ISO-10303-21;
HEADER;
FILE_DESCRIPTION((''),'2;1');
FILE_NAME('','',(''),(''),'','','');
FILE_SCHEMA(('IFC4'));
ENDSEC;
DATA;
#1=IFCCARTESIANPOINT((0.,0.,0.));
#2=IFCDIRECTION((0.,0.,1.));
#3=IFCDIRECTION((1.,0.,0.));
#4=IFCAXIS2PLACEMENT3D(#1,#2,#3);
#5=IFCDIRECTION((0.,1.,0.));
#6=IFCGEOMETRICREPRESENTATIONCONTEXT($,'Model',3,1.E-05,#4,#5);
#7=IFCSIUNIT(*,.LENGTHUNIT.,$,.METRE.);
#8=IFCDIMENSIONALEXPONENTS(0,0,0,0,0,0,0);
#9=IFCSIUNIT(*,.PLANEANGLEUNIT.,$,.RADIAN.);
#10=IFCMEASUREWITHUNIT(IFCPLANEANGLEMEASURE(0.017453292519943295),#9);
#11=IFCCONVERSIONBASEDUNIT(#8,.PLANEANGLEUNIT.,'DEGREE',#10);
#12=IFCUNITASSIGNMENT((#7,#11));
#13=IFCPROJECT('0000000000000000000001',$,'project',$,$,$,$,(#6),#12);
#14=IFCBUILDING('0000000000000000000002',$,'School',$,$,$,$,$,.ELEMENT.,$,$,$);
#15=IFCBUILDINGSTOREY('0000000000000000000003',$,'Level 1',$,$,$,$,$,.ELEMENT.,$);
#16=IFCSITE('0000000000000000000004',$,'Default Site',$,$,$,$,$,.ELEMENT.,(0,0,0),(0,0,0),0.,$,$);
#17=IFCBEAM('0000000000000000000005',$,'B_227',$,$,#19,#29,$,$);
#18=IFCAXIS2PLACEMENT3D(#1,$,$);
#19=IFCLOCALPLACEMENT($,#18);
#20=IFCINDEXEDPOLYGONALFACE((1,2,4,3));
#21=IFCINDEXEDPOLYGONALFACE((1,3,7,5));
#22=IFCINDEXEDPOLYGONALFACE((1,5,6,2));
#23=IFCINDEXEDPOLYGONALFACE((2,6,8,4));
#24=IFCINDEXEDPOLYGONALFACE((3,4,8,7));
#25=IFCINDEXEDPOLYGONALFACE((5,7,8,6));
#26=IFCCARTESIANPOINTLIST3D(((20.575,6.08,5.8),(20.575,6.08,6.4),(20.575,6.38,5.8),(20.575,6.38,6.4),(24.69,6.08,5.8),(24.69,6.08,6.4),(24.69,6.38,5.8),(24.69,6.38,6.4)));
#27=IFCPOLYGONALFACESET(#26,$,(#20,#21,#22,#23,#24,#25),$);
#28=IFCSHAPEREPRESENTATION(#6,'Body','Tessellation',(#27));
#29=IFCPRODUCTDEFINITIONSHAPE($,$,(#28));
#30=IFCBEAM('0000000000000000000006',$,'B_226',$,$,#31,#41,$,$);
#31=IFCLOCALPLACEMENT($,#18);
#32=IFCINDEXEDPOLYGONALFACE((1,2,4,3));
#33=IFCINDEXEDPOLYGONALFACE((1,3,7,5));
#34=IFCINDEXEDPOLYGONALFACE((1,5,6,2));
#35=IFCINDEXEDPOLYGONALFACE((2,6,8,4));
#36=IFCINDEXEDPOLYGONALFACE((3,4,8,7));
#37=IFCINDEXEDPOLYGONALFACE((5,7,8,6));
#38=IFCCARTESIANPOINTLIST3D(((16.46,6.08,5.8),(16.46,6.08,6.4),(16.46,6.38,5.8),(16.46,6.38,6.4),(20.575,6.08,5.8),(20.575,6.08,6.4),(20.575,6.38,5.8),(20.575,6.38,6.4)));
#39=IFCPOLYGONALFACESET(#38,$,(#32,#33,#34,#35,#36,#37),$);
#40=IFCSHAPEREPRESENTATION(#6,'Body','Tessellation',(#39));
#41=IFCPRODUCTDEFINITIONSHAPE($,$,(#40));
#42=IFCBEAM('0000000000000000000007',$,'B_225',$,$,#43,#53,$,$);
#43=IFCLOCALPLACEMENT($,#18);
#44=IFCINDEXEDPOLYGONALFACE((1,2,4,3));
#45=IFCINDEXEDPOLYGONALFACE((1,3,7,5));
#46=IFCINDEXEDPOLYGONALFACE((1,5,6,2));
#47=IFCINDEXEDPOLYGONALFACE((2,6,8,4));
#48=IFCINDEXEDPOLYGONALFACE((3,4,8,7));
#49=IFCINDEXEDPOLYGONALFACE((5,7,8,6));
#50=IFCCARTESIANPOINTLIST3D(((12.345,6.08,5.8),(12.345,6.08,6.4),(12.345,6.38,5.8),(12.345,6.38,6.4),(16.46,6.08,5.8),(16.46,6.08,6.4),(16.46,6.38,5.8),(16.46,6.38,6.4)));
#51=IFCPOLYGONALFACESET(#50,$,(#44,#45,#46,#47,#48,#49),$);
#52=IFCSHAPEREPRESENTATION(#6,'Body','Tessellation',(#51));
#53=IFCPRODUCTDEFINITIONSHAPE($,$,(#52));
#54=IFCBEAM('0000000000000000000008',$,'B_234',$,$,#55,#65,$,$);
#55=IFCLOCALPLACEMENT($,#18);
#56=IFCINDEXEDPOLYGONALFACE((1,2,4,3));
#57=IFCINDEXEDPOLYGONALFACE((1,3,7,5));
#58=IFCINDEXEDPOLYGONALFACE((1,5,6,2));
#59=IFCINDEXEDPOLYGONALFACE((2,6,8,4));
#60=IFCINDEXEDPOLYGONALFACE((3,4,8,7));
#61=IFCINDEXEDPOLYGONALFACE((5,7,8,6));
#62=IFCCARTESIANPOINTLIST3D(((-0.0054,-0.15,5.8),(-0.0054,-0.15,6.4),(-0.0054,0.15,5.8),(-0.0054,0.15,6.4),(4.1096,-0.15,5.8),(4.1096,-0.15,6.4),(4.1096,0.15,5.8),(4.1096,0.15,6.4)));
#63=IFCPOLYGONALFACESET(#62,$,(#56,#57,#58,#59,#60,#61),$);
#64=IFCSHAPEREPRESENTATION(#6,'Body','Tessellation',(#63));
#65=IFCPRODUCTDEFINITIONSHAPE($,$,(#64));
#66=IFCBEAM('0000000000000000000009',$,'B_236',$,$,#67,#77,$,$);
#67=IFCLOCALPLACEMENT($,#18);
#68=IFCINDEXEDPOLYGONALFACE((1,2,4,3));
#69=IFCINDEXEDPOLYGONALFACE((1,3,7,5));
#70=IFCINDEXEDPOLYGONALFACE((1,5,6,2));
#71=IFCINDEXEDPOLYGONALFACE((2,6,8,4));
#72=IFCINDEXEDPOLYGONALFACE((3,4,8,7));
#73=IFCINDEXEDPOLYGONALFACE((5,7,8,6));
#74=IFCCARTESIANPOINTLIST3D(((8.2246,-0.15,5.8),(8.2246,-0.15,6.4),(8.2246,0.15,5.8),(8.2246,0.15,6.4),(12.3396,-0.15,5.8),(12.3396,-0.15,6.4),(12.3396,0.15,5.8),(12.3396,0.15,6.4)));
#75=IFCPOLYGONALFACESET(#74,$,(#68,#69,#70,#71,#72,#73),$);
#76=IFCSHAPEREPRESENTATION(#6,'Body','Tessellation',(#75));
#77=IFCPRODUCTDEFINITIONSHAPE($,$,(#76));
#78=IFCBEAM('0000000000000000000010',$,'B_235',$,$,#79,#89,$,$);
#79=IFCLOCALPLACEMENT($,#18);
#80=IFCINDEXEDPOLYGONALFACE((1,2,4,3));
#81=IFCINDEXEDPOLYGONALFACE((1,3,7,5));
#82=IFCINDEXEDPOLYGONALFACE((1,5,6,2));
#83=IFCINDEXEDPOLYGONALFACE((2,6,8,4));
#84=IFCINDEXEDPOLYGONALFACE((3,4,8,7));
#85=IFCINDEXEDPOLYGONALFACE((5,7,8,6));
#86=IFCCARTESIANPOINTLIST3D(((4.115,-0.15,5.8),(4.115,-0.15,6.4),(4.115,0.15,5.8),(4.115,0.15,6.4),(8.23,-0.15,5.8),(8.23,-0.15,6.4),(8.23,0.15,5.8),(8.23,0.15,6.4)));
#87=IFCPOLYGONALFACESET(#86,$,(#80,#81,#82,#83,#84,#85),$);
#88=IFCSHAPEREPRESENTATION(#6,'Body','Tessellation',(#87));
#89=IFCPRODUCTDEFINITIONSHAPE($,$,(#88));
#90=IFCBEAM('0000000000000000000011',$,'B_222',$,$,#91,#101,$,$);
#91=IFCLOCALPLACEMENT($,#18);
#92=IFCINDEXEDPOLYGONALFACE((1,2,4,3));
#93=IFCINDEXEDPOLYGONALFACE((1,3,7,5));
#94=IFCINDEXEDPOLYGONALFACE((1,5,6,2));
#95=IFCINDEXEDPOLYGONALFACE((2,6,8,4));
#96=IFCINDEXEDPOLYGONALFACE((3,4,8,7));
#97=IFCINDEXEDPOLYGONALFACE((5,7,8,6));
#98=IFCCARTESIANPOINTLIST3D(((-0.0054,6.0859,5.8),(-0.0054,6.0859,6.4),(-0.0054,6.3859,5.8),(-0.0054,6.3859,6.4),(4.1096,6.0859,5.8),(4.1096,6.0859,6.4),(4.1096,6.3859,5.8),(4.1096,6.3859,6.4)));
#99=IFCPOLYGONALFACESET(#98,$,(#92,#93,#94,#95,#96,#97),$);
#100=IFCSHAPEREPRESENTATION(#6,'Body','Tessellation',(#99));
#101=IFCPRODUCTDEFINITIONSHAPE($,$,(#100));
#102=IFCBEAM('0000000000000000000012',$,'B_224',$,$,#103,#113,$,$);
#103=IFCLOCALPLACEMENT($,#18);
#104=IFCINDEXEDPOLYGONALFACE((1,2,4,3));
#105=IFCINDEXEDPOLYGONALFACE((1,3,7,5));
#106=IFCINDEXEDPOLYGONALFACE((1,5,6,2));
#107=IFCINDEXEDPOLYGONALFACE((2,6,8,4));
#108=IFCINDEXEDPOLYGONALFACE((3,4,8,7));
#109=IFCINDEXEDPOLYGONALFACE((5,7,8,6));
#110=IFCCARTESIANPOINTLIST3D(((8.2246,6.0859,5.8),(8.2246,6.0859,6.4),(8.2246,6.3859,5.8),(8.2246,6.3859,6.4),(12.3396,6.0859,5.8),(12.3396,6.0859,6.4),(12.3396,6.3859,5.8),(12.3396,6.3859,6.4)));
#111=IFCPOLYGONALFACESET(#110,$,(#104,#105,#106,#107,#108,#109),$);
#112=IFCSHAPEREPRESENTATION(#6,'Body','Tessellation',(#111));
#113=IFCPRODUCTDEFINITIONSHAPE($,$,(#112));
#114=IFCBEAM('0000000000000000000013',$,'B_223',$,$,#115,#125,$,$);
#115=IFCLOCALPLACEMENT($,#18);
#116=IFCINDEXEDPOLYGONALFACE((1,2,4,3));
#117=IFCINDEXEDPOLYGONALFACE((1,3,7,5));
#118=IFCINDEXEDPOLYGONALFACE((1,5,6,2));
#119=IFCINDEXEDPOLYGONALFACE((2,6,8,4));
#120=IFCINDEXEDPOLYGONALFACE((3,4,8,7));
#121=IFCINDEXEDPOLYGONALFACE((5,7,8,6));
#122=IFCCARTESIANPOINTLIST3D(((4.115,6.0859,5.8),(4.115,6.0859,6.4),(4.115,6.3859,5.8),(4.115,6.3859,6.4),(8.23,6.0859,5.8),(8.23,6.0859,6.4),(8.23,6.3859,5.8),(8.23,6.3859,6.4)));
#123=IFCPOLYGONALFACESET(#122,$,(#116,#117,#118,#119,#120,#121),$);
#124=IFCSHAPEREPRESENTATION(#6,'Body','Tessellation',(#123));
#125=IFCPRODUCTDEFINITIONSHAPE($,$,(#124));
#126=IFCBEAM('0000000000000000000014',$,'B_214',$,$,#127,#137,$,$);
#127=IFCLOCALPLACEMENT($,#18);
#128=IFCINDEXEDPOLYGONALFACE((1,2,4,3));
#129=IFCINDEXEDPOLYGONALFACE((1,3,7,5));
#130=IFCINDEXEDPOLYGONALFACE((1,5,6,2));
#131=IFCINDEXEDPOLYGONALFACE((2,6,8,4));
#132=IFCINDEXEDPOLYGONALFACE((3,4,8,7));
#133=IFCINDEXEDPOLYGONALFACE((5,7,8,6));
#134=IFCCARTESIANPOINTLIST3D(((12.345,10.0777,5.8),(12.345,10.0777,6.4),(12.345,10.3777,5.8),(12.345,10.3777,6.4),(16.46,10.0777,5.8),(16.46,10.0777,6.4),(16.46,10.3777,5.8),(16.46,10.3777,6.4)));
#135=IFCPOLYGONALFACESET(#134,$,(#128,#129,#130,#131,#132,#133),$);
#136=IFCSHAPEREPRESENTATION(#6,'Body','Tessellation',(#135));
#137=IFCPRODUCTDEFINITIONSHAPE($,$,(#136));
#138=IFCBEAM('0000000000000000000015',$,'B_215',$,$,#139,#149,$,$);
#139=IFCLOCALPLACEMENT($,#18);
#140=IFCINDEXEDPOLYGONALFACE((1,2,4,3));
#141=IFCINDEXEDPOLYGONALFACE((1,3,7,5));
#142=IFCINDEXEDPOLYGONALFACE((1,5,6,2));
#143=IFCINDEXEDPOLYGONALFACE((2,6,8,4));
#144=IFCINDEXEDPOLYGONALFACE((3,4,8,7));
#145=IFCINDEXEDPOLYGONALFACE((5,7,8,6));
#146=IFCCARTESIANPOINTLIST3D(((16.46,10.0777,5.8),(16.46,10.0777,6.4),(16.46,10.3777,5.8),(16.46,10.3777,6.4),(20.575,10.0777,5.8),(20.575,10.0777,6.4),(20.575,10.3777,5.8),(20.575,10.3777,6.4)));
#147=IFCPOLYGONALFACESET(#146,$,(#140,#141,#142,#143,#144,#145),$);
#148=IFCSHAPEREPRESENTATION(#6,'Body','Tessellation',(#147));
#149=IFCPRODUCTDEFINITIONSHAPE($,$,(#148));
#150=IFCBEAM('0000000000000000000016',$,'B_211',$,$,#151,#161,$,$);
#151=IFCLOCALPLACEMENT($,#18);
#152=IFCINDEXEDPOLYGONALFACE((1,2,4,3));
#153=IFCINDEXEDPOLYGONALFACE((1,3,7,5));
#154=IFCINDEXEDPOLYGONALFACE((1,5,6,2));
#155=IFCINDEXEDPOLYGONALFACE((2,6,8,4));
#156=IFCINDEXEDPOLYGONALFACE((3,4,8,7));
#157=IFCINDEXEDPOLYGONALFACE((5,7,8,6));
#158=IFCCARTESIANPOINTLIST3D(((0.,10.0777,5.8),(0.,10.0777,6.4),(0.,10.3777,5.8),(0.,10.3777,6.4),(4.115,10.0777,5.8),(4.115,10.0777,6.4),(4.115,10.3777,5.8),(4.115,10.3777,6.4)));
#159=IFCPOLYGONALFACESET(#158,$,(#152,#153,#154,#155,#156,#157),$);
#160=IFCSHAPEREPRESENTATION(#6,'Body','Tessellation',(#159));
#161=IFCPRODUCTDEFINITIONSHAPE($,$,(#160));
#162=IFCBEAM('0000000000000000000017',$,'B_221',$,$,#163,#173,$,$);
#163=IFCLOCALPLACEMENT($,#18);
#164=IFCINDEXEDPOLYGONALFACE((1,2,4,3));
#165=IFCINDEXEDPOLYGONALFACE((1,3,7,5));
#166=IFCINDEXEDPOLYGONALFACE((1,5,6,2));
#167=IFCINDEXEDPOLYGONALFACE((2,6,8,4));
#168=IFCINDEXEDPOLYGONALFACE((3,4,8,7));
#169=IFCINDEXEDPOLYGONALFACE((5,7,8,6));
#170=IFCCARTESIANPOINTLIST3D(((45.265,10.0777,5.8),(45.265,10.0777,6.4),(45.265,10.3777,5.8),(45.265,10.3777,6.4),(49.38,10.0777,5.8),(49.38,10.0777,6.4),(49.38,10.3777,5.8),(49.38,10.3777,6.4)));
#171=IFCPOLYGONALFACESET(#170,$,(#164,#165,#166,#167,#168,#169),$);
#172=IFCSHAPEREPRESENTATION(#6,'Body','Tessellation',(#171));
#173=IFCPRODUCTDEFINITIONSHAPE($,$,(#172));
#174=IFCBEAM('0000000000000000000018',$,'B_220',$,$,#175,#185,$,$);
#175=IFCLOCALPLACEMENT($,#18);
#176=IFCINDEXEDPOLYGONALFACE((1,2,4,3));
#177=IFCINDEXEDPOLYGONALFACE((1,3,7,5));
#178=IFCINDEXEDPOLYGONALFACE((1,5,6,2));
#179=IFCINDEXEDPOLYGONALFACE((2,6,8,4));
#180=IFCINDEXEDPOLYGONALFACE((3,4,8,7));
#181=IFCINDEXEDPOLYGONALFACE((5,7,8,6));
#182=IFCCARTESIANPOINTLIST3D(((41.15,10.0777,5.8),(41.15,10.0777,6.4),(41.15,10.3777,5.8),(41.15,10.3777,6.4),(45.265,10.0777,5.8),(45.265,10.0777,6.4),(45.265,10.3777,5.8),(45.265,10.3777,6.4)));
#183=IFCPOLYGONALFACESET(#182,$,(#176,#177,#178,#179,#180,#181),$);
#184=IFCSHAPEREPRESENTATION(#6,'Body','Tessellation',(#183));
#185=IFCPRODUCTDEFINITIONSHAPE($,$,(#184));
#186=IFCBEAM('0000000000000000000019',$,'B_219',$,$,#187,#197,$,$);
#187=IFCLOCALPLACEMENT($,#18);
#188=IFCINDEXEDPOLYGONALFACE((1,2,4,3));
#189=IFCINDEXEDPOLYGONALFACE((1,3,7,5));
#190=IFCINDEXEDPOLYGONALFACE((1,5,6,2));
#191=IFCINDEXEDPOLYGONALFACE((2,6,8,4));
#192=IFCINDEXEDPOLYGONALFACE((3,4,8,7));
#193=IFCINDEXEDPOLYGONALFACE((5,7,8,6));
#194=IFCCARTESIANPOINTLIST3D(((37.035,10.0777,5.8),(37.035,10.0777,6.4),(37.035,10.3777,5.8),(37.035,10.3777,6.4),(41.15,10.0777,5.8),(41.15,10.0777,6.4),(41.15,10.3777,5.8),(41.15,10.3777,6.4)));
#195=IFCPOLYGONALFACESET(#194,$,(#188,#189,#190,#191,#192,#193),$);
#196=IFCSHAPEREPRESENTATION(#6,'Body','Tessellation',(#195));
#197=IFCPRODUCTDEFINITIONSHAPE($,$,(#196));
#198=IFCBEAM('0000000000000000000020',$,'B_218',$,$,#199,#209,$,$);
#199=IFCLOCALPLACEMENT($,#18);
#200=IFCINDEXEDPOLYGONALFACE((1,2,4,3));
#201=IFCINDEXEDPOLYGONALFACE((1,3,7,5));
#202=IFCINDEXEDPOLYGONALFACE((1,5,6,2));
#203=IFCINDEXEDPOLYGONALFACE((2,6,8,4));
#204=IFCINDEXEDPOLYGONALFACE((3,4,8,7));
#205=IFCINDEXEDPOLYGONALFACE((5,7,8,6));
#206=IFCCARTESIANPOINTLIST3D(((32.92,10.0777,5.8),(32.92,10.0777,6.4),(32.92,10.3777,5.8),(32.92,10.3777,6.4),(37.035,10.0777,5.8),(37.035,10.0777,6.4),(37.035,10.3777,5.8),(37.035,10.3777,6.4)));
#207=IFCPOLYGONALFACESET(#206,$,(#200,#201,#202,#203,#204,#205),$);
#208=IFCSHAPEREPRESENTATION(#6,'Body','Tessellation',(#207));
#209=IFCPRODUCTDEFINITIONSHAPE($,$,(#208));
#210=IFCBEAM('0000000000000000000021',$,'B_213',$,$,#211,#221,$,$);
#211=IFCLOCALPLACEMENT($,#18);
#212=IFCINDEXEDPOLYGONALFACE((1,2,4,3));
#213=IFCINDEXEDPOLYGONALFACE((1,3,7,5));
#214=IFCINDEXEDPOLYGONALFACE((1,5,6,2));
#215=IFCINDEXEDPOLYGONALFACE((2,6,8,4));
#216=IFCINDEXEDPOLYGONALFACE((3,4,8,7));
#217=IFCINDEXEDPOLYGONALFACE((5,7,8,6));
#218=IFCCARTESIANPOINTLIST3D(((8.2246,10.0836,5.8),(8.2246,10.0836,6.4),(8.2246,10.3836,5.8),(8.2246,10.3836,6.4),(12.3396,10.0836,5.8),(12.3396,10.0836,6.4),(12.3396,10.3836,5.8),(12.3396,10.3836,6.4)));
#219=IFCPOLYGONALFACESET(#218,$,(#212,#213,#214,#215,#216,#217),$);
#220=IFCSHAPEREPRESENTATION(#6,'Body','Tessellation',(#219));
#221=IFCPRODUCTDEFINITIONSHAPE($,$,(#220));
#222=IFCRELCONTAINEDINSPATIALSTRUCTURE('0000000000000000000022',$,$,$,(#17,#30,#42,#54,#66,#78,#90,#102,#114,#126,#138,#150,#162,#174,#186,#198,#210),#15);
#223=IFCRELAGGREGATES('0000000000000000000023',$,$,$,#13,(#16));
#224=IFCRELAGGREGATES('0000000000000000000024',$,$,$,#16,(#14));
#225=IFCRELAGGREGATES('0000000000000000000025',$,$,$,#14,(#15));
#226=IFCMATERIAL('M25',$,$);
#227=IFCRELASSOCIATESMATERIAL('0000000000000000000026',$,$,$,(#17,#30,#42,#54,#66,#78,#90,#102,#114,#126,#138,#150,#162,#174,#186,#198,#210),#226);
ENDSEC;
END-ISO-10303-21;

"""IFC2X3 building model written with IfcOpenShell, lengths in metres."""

from ifc_helpers import new_model, entity, si_unit, converted_unit, direction, frame, frame_2d, origin_with_axes, place, context, project, spatial, rectangle, extrude, material, element, save


model = new_model("IFC2X3")

# Units and contexts
model_context = context("Model", 3, precision=1e-05, world=origin_with_axes(), true_north=direction((0.0, 1.0, 0.0)))
ifc_project = project(units=[si_unit("LENGTHUNIT", "METRE"), converted_unit("PLANEANGLEUNIT", "DEGREE", entity("IfcPlaneAngleMeasure", 0.017453292519943295), si_unit("PLANEANGLEUNIT", "RADIAN"), dimensions=[0, 0, 0, 0, 0, 0, 0])], contexts=[model_context])

# Site, building, storey
site = spatial("IfcSite", under=ifc_project, Name="Default Site", CompositionType="ELEMENT", RefLatitude=(0, 0, 0), RefLongitude=(0, 0, 0), RefElevation=0.0)
building = spatial("IfcBuilding", under=site, Name="School", CompositionType="ELEMENT")
storey = spatial("IfcBuildingStorey", under=building, Name="Level 1", CompositionType="ELEMENT")

# Beams
ifc_material = material(Name="M25")
placement = place(None, origin_with_axes())
element("IfcBeam", 1, at=placement, inside=storey, material=ifc_material, Name="B_227", context=model_context, shape_type="SweptSolid", body=[
    extrude(rectangle(XDim=0.3, YDim=0.6, at=frame_2d((0.0, 0.0), x_axis=(0.0, 1.0, 0.0))), frame((20.575, 6.23, 6.1), z_axis=(1.0, 0.0, 0.0), x_axis=(0.0, 0.0, -1.0)), (0.0, 0.0, 1.0), 4.115),
])
element("IfcBeam", 2, at=placement, inside=storey, material=ifc_material, Name="B_226", context=model_context, shape_type="SweptSolid", body=[
    extrude(rectangle(XDim=0.3, YDim=0.6, at=frame_2d((0.0, 0.0), x_axis=(0.0, 1.0, 0.0))), frame((16.46, 6.23, 6.1), z_axis=(1.0, 0.0, 0.0), x_axis=(0.0, 0.0, -1.0)), (0.0, 0.0, 1.0), 4.115),
])
element("IfcBeam", 3, at=placement, inside=storey, material=ifc_material, Name="B_225", context=model_context, shape_type="SweptSolid", body=[
    extrude(rectangle(XDim=0.3, YDim=0.6, at=frame_2d((0.0, 0.0), x_axis=(0.0, 1.0, 0.0))), frame((12.345, 6.23, 6.1), z_axis=(1.0, 0.0, 0.0), x_axis=(0.0, 0.0, -1.0)), (0.0, 0.0, 1.0), 4.115),
])
element("IfcBeam", 4, at=placement, inside=storey, material=ifc_material, Name="B_234", context=model_context, shape_type="SweptSolid", body=[
    extrude(rectangle(XDim=0.3, YDim=0.6, at=frame_2d((0.0, 0.0), x_axis=(0.0, 1.0, 0.0))), frame((-0.0054, 0.0, 6.1), z_axis=(1.0, 0.0, 0.0), x_axis=(0.0, 0.0, -1.0)), (0.0, 0.0, 1.0), 4.115),
])
element("IfcBeam", 5, at=placement, inside=storey, material=ifc_material, Name="B_236", context=model_context, shape_type="SweptSolid", body=[
    extrude(rectangle(XDim=0.3, YDim=0.6, at=frame_2d((0.0, 0.0), x_axis=(0.0, 1.0, 0.0))), frame((8.2246, 0.0, 6.1), z_axis=(1.0, 0.0, 0.0), x_axis=(0.0, 0.0, -1.0)), (0.0, 0.0, 1.0), 4.115),
])
element("IfcBeam", 6, at=placement, inside=storey, material=ifc_material, Name="B_235", context=model_context, shape_type="SweptSolid", body=[
    extrude(rectangle(XDim=0.3, YDim=0.6, at=frame_2d((0.0, 0.0), x_axis=(0.0, 1.0, 0.0))), frame((4.115, 0.0, 6.1), z_axis=(1.0, 0.0, 0.0), x_axis=(0.0, 0.0, -1.0)), (0.0, 0.0, 1.0), 4.115),
])
element("IfcBeam", 7, at=placement, inside=storey, material=ifc_material, Name="B_222", context=model_context, shape_type="SweptSolid", body=[
    extrude(rectangle(XDim=0.3, YDim=0.6, at=frame_2d((0.0, 0.0), x_axis=(0.0, 1.0, 0.0))), frame((-0.0054, 6.2359, 6.1), z_axis=(1.0, 0.0, 0.0), x_axis=(0.0, 0.0, -1.0)), (0.0, 0.0, 1.0), 4.115),
])
element("IfcBeam", 8, at=placement, inside=storey, material=ifc_material, Name="B_224", context=model_context, shape_type="SweptSolid", body=[
    extrude(rectangle(XDim=0.3, YDim=0.6, at=frame_2d((0.0, 0.0), x_axis=(0.0, 1.0, 0.0))), frame((8.2246, 6.2359, 6.1), z_axis=(1.0, 0.0, 0.0), x_axis=(0.0, 0.0, -1.0)), (0.0, 0.0, 1.0), 4.115),
])
element("IfcBeam", 9, at=placement, inside=storey, material=ifc_material, Name="B_223", context=model_context, shape_type="SweptSolid", body=[
    extrude(rectangle(XDim=0.3, YDim=0.6, at=frame_2d((0.0, 0.0), x_axis=(0.0, 1.0, 0.0))), frame((4.115, 6.2359, 6.1), z_axis=(1.0, 0.0, 0.0), x_axis=(0.0, 0.0, -1.0)), (0.0, 0.0, 1.0), 4.115),
])
element("IfcBeam", 10, at=placement, inside=storey, material=ifc_material, Name="B_214", context=model_context, shape_type="SweptSolid", body=[
    extrude(rectangle(XDim=0.3, YDim=0.6, at=frame_2d((0.0, 0.0), x_axis=(0.0, 1.0, 0.0))), frame((12.345, 10.2277, 6.1), z_axis=(1.0, 0.0, 0.0), x_axis=(0.0, 0.0, -1.0)), (0.0, 0.0, 1.0), 4.115),
])
element("IfcBeam", 11, at=placement, inside=storey, material=ifc_material, Name="B_215", context=model_context, shape_type="SweptSolid", body=[
    extrude(rectangle(XDim=0.3, YDim=0.6, at=frame_2d((0.0, 0.0), x_axis=(0.0, 1.0, 0.0))), frame((16.46, 10.2277, 6.1), z_axis=(1.0, 0.0, 0.0), x_axis=(0.0, 0.0, -1.0)), (0.0, 0.0, 1.0), 4.115),
])
element("IfcBeam", 12, at=placement, inside=storey, material=ifc_material, Name="B_211", context=model_context, shape_type="SweptSolid", body=[
    extrude(rectangle(XDim=0.3, YDim=0.6, at=frame_2d((0.0, 0.0), x_axis=(0.0, 1.0, 0.0))), frame((0.0, 10.2277, 6.1), z_axis=(1.0, 0.0, 0.0), x_axis=(0.0, 0.0, -1.0)), (0.0, 0.0, 1.0), 4.115),
])
element("IfcBeam", 13, at=placement, inside=storey, material=ifc_material, Name="B_221", context=model_context, shape_type="SweptSolid", body=[
    extrude(rectangle(XDim=0.3, YDim=0.6, at=frame_2d((0.0, 0.0), x_axis=(0.0, 1.0, 0.0))), frame((45.265, 10.2277, 6.1), z_axis=(1.0, 0.0, 0.0), x_axis=(0.0, 0.0, -1.0)), (0.0, 0.0, 1.0), 4.115),
])
element("IfcBeam", 14, at=placement, inside=storey, material=ifc_material, Name="B_220", context=model_context, shape_type="SweptSolid", body=[
    extrude(rectangle(XDim=0.3, YDim=0.6, at=frame_2d((0.0, 0.0), x_axis=(0.0, 1.0, 0.0))), frame((41.15, 10.2277, 6.1), z_axis=(1.0, 0.0, 0.0), x_axis=(0.0, 0.0, -1.0)), (0.0, 0.0, 1.0), 4.115),
])
element("IfcBeam", 15, at=placement, inside=storey, material=ifc_material, Name="B_219", context=model_context, shape_type="SweptSolid", body=[
    extrude(rectangle(XDim=0.3, YDim=0.6, at=frame_2d((0.0, 0.0), x_axis=(0.0, 1.0, 0.0))), frame((37.035, 10.2277, 6.1), z_axis=(1.0, 0.0, 0.0), x_axis=(0.0, 0.0, -1.0)), (0.0, 0.0, 1.0), 4.115),
])
element("IfcBeam", 16, at=placement, inside=storey, material=ifc_material, Name="B_218", context=model_context, shape_type="SweptSolid", body=[
    extrude(rectangle(XDim=0.3, YDim=0.6, at=frame_2d((0.0, 0.0), x_axis=(0.0, 1.0, 0.0))), frame((32.92, 10.2277, 6.1), z_axis=(1.0, 0.0, 0.0), x_axis=(0.0, 0.0, -1.0)), (0.0, 0.0, 1.0), 4.115),
])
element("IfcBeam", 17, at=placement, inside=storey, material=ifc_material, Name="B_213", context=model_context, shape_type="SweptSolid", body=[
    extrude(rectangle(XDim=0.3, YDim=0.6, at=frame_2d((0.0, 0.0), x_axis=(0.0, 1.0, 0.0))), frame((8.2246, 10.2336, 6.1), z_axis=(1.0, 0.0, 0.0), x_axis=(0.0, 0.0, -1.0)), (0.0, 0.0, 1.0), 4.115),
])

save(model, "model.ifc")
